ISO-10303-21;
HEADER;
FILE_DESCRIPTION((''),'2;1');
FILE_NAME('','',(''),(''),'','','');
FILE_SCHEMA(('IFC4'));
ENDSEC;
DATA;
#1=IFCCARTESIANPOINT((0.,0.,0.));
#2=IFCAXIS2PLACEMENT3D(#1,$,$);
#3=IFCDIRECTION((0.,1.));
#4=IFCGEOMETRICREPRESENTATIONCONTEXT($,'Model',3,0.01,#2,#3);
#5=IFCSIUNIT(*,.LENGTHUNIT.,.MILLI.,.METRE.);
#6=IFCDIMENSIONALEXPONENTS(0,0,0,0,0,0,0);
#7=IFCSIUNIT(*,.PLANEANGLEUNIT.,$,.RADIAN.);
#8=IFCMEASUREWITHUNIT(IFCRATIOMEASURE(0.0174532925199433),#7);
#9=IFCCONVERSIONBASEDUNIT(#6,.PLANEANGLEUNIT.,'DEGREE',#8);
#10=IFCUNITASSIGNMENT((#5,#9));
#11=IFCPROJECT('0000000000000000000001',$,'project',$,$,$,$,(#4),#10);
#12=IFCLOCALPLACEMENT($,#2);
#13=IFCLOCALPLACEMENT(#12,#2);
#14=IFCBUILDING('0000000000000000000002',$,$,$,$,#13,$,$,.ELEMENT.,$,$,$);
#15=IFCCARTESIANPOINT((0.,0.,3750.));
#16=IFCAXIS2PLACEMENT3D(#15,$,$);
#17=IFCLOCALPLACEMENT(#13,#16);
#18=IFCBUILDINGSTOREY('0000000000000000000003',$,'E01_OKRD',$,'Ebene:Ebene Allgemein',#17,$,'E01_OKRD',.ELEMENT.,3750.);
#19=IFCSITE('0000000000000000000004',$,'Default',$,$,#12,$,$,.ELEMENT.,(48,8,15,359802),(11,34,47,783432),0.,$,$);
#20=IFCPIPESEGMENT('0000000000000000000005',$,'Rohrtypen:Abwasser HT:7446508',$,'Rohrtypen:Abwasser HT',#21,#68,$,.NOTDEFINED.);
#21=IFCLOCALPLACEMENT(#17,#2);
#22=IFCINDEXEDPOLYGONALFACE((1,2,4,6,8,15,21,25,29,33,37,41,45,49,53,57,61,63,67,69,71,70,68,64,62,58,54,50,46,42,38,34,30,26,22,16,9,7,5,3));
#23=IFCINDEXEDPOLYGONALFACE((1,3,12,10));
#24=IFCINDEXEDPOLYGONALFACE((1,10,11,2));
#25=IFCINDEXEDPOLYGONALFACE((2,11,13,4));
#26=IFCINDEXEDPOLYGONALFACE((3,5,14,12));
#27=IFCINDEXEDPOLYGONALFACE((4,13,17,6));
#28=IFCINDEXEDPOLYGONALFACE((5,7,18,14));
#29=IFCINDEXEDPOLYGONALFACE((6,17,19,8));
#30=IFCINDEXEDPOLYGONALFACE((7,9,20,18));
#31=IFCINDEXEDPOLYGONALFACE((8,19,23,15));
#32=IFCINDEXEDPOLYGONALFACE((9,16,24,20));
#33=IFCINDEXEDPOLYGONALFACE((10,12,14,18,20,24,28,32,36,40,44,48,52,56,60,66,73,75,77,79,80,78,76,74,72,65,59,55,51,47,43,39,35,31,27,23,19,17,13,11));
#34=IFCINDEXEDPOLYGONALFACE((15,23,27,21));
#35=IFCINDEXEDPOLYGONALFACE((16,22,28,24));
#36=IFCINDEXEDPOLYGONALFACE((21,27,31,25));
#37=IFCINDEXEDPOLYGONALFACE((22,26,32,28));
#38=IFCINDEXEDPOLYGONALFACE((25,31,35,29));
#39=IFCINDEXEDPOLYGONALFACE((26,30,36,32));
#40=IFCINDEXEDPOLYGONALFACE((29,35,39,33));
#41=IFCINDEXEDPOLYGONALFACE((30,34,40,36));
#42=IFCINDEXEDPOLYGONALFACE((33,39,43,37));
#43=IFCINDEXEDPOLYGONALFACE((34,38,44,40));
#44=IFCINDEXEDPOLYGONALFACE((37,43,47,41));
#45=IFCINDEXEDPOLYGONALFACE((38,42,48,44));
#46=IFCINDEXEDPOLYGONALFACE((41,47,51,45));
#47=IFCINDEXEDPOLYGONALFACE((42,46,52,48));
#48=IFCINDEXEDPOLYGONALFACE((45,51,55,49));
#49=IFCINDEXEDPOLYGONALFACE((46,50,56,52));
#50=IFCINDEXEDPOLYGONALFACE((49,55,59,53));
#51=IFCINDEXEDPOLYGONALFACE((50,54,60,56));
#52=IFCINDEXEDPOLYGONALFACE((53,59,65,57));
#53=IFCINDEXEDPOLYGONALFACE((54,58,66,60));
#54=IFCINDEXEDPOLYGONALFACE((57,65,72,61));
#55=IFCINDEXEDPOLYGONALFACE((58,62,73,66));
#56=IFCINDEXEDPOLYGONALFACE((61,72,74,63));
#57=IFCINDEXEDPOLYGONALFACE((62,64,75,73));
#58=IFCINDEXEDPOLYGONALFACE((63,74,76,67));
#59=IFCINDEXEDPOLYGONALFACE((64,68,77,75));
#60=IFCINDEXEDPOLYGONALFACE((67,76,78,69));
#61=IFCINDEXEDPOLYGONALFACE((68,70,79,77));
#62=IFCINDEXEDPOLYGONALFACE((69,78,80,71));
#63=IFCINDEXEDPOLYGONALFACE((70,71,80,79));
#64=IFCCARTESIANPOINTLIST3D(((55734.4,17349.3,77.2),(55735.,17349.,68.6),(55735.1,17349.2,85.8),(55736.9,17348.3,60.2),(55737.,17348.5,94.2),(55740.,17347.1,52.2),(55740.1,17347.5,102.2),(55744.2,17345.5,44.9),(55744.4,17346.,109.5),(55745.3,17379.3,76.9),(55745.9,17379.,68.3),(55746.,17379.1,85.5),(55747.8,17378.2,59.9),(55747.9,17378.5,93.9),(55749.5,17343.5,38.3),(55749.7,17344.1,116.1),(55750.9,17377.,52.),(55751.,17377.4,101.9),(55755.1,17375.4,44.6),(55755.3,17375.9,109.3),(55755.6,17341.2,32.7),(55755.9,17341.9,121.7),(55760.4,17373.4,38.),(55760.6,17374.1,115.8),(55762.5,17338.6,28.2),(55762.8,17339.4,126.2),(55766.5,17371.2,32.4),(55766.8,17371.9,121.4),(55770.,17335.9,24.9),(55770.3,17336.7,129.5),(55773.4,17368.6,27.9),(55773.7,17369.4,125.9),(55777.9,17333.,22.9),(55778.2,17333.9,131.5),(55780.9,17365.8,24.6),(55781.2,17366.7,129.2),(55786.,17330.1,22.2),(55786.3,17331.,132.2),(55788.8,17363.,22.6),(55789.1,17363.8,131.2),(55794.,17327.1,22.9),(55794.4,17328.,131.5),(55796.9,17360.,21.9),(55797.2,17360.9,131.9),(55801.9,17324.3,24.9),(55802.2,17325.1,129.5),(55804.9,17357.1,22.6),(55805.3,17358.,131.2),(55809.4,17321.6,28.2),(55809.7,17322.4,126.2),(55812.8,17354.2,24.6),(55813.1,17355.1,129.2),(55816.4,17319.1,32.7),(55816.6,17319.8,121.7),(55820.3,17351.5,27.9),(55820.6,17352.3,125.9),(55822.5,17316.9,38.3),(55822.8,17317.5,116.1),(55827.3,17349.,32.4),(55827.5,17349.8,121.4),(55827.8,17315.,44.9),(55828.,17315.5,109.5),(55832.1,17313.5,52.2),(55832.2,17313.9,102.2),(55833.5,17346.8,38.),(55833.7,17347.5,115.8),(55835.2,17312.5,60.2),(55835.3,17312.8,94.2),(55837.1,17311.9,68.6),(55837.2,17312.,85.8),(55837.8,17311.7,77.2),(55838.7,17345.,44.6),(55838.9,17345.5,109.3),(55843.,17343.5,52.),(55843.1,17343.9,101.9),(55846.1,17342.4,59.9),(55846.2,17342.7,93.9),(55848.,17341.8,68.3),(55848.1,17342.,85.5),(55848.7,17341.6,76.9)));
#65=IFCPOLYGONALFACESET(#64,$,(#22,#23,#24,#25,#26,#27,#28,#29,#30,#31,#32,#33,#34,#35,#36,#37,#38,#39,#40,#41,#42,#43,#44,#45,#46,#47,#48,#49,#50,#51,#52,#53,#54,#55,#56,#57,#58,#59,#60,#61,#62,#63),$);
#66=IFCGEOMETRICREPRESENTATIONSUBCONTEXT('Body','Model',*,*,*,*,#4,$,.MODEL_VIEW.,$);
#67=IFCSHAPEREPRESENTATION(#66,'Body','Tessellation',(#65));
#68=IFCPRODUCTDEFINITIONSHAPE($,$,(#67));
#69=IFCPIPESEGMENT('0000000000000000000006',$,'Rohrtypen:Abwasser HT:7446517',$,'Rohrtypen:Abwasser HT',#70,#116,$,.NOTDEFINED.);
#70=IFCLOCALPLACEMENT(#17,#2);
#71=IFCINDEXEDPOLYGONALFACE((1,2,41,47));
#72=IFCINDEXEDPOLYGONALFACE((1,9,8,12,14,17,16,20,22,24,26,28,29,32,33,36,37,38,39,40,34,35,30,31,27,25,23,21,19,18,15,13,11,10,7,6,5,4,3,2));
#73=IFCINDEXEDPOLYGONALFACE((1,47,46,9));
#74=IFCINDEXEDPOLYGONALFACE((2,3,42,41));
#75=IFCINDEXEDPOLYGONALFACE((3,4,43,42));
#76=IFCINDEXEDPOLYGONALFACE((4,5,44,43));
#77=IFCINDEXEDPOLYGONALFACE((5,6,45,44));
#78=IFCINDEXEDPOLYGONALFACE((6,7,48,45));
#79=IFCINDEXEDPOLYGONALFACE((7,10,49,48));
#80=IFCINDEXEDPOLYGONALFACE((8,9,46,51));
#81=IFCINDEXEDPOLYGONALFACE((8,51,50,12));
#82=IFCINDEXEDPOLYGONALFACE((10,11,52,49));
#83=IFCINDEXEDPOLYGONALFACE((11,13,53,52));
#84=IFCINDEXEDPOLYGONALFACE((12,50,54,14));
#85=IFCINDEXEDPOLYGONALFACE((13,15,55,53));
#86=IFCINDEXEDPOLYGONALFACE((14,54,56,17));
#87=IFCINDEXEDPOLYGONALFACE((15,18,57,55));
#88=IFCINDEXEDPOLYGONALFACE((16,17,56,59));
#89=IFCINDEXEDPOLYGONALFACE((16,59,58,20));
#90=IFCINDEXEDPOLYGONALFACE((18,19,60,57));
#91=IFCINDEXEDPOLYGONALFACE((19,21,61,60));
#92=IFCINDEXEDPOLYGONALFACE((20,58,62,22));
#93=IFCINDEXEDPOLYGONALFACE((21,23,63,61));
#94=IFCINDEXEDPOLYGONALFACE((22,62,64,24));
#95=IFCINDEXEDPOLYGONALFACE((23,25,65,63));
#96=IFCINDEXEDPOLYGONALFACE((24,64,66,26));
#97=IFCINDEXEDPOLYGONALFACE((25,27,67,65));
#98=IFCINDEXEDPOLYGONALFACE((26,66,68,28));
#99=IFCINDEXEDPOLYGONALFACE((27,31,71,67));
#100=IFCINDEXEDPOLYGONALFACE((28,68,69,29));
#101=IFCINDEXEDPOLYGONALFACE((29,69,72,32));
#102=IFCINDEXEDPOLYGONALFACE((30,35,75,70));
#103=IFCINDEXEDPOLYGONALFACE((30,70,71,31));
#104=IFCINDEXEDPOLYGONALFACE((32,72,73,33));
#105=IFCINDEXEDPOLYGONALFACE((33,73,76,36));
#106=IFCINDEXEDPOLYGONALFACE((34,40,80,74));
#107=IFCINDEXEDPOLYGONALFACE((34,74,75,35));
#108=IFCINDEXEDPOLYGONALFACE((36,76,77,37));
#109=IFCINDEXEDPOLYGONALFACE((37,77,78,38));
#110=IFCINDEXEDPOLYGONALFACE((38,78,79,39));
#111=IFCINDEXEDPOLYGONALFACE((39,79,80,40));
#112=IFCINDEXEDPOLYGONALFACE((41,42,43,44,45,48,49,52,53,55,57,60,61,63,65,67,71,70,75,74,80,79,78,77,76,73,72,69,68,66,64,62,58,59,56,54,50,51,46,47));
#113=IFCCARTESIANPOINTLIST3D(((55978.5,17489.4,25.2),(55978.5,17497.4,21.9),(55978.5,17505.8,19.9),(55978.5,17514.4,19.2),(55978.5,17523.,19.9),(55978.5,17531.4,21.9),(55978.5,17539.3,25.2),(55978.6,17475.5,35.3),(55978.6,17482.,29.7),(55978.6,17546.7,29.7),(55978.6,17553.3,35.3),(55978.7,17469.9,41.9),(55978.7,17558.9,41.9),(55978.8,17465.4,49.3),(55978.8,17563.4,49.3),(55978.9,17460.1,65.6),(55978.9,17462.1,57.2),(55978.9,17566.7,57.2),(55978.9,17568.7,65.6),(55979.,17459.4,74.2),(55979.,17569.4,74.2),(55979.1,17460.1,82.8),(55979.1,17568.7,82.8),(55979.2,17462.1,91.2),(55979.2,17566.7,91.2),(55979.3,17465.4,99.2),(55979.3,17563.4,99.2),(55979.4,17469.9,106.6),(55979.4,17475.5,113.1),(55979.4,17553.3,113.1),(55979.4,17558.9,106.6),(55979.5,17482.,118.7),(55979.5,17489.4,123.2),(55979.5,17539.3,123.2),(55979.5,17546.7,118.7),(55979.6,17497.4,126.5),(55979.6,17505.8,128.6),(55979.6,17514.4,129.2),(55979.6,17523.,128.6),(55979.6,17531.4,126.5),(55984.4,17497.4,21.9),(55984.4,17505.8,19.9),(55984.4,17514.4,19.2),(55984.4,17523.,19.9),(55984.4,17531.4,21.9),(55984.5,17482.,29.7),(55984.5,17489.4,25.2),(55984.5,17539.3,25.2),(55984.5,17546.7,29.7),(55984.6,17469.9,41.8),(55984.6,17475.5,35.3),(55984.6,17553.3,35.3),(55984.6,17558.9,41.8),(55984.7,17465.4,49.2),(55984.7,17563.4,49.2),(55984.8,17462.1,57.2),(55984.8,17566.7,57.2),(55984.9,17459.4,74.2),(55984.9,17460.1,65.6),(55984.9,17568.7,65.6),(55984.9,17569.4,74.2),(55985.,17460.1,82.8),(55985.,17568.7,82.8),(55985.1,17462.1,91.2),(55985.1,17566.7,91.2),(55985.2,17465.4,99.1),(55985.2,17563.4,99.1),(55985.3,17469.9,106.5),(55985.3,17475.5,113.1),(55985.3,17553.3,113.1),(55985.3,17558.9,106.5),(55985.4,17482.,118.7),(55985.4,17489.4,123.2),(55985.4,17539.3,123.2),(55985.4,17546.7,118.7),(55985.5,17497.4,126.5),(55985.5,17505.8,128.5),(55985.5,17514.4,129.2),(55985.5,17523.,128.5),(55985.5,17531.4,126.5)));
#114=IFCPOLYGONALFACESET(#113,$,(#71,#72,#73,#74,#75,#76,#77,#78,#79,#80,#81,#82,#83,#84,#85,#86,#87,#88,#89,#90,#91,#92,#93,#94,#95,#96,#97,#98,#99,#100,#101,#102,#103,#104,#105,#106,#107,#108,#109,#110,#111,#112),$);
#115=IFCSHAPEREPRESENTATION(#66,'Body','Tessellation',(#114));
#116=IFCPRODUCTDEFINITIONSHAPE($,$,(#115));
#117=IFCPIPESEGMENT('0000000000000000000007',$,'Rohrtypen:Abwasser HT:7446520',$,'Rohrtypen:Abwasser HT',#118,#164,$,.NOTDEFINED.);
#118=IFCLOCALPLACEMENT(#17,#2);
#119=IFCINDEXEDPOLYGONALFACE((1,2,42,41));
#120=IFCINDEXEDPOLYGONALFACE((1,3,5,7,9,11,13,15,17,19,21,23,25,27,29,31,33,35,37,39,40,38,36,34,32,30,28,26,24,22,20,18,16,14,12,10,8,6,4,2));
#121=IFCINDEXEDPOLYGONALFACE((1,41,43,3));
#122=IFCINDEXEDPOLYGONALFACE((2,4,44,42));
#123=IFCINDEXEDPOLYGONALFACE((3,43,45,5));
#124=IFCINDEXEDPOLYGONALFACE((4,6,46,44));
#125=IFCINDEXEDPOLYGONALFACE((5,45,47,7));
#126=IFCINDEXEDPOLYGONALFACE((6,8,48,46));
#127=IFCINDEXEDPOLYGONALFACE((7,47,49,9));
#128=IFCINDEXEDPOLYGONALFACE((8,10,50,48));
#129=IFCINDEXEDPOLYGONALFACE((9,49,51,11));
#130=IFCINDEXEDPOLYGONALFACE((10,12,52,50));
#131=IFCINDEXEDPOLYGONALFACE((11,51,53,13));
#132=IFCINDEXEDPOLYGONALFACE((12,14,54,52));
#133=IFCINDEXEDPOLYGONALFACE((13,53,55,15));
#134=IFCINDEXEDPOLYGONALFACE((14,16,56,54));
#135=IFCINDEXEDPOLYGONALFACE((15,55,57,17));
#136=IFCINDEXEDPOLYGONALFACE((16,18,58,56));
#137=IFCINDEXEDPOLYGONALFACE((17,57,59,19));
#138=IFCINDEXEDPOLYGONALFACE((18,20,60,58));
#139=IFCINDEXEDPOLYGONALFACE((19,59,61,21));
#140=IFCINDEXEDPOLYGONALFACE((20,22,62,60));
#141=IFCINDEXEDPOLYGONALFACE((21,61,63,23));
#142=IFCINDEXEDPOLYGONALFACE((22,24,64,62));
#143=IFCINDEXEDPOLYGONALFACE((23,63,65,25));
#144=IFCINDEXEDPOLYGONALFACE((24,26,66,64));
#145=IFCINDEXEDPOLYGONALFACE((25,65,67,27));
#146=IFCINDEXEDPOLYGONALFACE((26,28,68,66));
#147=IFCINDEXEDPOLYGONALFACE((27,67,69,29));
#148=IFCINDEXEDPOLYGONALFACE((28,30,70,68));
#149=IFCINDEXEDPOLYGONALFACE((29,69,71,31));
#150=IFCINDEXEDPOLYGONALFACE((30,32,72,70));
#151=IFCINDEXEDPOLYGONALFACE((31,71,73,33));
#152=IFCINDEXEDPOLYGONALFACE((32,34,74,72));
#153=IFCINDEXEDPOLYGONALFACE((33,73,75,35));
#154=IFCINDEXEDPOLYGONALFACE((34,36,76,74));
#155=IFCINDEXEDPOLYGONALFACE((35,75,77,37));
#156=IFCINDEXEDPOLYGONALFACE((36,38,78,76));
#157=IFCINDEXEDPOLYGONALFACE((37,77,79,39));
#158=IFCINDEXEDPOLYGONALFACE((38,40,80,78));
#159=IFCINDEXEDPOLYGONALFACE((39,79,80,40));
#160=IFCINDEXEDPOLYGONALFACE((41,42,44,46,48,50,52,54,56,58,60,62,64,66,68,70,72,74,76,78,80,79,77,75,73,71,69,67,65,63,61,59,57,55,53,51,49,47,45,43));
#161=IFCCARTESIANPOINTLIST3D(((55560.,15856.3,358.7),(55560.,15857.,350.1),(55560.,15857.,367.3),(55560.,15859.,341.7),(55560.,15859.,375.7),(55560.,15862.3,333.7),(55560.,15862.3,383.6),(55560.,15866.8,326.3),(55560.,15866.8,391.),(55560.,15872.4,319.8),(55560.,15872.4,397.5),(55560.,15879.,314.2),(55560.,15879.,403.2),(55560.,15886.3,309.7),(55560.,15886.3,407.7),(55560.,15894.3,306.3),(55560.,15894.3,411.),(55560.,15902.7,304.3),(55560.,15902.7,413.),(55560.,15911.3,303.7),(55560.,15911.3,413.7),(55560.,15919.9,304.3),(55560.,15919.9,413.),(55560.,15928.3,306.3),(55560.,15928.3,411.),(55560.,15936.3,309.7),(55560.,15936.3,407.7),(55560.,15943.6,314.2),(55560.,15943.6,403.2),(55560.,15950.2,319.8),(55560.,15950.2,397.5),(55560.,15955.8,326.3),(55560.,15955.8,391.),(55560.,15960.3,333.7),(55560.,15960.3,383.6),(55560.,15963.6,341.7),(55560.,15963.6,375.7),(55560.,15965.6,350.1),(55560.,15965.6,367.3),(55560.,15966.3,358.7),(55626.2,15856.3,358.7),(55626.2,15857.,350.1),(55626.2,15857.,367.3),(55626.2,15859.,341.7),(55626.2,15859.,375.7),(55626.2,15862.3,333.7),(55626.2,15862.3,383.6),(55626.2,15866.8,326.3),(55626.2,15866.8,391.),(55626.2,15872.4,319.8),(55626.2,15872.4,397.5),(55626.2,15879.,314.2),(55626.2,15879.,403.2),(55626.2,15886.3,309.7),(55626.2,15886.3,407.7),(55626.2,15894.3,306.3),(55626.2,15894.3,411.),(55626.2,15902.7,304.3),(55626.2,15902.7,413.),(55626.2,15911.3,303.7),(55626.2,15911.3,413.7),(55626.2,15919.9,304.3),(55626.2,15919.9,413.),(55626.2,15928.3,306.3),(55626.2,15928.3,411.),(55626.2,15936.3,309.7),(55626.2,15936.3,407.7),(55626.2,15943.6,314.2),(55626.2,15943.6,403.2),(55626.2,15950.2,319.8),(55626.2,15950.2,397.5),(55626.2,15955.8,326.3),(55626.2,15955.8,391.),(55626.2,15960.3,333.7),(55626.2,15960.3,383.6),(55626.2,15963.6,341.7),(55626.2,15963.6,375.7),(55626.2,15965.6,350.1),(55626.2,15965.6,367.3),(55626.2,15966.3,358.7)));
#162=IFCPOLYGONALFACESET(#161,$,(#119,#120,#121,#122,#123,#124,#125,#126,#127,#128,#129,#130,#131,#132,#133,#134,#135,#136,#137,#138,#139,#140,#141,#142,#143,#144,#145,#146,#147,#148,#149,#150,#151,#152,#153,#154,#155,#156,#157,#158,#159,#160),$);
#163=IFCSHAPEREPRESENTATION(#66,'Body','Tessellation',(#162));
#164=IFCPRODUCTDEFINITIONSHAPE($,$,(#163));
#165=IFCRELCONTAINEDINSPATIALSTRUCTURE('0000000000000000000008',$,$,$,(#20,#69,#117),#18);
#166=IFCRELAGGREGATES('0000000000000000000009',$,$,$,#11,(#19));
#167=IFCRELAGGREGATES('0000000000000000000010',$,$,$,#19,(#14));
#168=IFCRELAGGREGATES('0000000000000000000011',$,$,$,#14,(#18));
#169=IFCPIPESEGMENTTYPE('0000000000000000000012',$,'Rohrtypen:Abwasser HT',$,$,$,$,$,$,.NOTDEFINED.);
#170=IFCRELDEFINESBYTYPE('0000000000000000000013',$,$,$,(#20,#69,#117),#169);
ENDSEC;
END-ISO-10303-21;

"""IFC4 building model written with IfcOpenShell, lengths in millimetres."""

from ifc_helpers import new_model, entity, si_unit, converted_unit, direction, frame, origin, place, context, subcontext, project, spatial, indexed_curve, outline, extrude, type_object, element, save


model = new_model("IFC4")

# Units and contexts
model_context = context("Model", 3, precision=0.01, world=origin(), true_north=direction((0.0, 1.0)))
body_context = subcontext(model_context, "Body", "Model", "MODEL_VIEW")
ifc_project = project(units=[si_unit("LENGTHUNIT", "METRE", prefix="MILLI"), converted_unit("PLANEANGLEUNIT", "DEGREE", entity("IfcRatioMeasure", 0.0174532925199433), si_unit("PLANEANGLEUNIT", "RADIAN"), dimensions=[0, 0, 0, 0, 0, 0, 0])], contexts=[model_context])

# Site, building, storey
site_placement = place(None, origin())
site = spatial("IfcSite", under=ifc_project, at=site_placement, Name="Default", CompositionType="ELEMENT", RefLatitude=(48, 8, 15, 359802), RefLongitude=(11, 34, 47, 783432), RefElevation=0.0)
building_placement = place(site_placement, origin())
building = spatial("IfcBuilding", under=site, at=building_placement, CompositionType="ELEMENT")
storey_placement = place(building_placement, frame((0.0, 0.0, 3750.0)))
storey = spatial("IfcBuildingStorey", under=building, at=storey_placement, Name="E01_OKRD", ObjectType="Ebene:Ebene Allgemein", LongName="E01_OKRD", CompositionType="ELEMENT", Elevation=3750.0)

# Pipe segments
pipe_segment_type_1 = type_object("IfcPipeSegmentType", Name="Rohrtypen:Abwasser HT", PredefinedType="NOTDEFINED")
pipe_segment_1_placement = place(storey_placement, origin())
element("IfcPipeSegment", 1, at=pipe_segment_1_placement, inside=storey, type_object=pipe_segment_type_1, Name="Rohrtypen:Abwasser HT:7446508", ObjectType="Rohrtypen:Abwasser HT", PredefinedType="NOTDEFINED", context=body_context, shape_type="SweptSolid", body=[
    extrude(outline(indexed_curve([(55.0, 0.0), (54.3, 8.6), (52.3, 17.0), (49.0, 25.0), (44.5, 32.3), (38.9, 38.9), (32.3, 44.5), (25.0, 49.0), (17.0, 52.3), (8.6, 54.3), (0.0, 55.0), (-8.6, 54.3), (-17.0, 52.3), (-25.0, 49.0), (-32.3, 44.5), (-38.9, 38.9), (-44.5, 32.3), (-49.0, 25.0), (-52.3, 17.0), (-54.3, 8.6), (-55.0, 0.0), (-54.3, -8.6), (-52.3, -17.0), (-49.0, -25.0), (-44.5, -32.3), (-38.9, -38.9), (-32.3, -44.5), (-25.0, -49.0), (-17.0, -52.3), (-8.6, -54.3), (0.0, -55.0), (8.6, -54.3), (17.0, -52.3), (25.0, -49.0), (32.3, -44.5), (38.9, -38.9), (44.5, -32.3), (49.0, -25.0), (52.3, -17.0), (54.3, -8.6), (55.0, 0.0)], self_intersect=False)), frame((55786.1, 17330.5, 77.2), z_axis=(0.342007, 0.939657, -0.008738), x_axis=(0.939693, -0.34202, 0.0)), (0.0, 0.0, 1.0), 31.9),
])
pipe_segment_2_placement = place(storey_placement, origin())
element("IfcPipeSegment", 2, at=pipe_segment_2_placement, inside=storey, type_object=pipe_segment_type_1, Name="Rohrtypen:Abwasser HT:7446517", ObjectType="Rohrtypen:Abwasser HT", PredefinedType="NOTDEFINED", context=body_context, shape_type="SweptSolid", body=[
    extrude(outline(indexed_curve([(55.0, 0.0), (54.3, 8.6), (52.3, 17.0), (49.0, 25.0), (44.5, 32.3), (38.9, 38.9), (32.3, 44.5), (25.0, 49.0), (17.0, 52.3), (8.6, 54.3), (0.0, 55.0), (-8.6, 54.3), (-17.0, 52.3), (-25.0, 49.0), (-32.3, 44.5), (-38.9, 38.9), (-44.5, 32.3), (-49.0, 25.0), (-52.3, 17.0), (-54.3, 8.6), (-55.0, 0.0), (-54.3, -8.6), (-52.3, -17.0), (-49.0, -25.0), (-44.5, -32.3), (-38.9, -38.9), (-32.3, -44.5), (-25.0, -49.0), (-17.0, -52.3), (-8.6, -54.3), (0.0, -55.0), (8.6, -54.3), (17.0, -52.3), (25.0, -49.0), (32.3, -44.5), (38.9, -38.9), (44.5, -32.3), (49.0, -25.0), (52.3, -17.0), (54.3, -8.6), (55.0, 0.0)], self_intersect=False)), frame((55984.9, 17514.4, 74.2), z_axis=(-0.99995, 0.0, 0.01), x_axis=(0.0, -1.0, 0.0)), (0.0, 0.0, 1.0), 5.9),
])
pipe_segment_3_placement = place(storey_placement, origin())
element("IfcPipeSegment", 3, at=pipe_segment_3_placement, inside=storey, type_object=pipe_segment_type_1, Name="Rohrtypen:Abwasser HT:7446520", ObjectType="Rohrtypen:Abwasser HT", PredefinedType="NOTDEFINED", context=body_context, shape_type="SweptSolid", body=[
    extrude(outline(indexed_curve([(55.0, 0.0), (54.3, 8.6), (52.3, 17.0), (49.0, 25.0), (44.5, 32.3), (38.9, 38.9), (32.3, 44.5), (25.0, 49.0), (17.0, 52.3), (8.6, 54.3), (0.0, 55.0), (-8.6, 54.3), (-17.0, 52.3), (-25.0, 49.0), (-32.3, 44.5), (-38.9, 38.9), (-44.5, 32.3), (-49.0, 25.0), (-52.3, 17.0), (-54.3, 8.6), (-55.0, 0.0), (-54.3, -8.6), (-52.3, -17.0), (-49.0, -25.0), (-44.5, -32.3), (-38.9, -38.9), (-32.3, -44.5), (-25.0, -49.0), (-17.0, -52.3), (-8.6, -54.3), (0.0, -55.0), (8.6, -54.3), (17.0, -52.3), (25.0, -49.0), (32.3, -44.5), (38.9, -38.9), (44.5, -32.3), (49.0, -25.0), (52.3, -17.0), (54.3, -8.6), (55.0, 0.0)], self_intersect=False)), frame((55560.0, 15911.3, 358.7), z_axis=(1.0, 0.0, 0.0), x_axis=(0.0, -1.0, -0.000001)), (0.0, 0.0, 1.0), 66.3),
])

save(model, "model.ifc")
